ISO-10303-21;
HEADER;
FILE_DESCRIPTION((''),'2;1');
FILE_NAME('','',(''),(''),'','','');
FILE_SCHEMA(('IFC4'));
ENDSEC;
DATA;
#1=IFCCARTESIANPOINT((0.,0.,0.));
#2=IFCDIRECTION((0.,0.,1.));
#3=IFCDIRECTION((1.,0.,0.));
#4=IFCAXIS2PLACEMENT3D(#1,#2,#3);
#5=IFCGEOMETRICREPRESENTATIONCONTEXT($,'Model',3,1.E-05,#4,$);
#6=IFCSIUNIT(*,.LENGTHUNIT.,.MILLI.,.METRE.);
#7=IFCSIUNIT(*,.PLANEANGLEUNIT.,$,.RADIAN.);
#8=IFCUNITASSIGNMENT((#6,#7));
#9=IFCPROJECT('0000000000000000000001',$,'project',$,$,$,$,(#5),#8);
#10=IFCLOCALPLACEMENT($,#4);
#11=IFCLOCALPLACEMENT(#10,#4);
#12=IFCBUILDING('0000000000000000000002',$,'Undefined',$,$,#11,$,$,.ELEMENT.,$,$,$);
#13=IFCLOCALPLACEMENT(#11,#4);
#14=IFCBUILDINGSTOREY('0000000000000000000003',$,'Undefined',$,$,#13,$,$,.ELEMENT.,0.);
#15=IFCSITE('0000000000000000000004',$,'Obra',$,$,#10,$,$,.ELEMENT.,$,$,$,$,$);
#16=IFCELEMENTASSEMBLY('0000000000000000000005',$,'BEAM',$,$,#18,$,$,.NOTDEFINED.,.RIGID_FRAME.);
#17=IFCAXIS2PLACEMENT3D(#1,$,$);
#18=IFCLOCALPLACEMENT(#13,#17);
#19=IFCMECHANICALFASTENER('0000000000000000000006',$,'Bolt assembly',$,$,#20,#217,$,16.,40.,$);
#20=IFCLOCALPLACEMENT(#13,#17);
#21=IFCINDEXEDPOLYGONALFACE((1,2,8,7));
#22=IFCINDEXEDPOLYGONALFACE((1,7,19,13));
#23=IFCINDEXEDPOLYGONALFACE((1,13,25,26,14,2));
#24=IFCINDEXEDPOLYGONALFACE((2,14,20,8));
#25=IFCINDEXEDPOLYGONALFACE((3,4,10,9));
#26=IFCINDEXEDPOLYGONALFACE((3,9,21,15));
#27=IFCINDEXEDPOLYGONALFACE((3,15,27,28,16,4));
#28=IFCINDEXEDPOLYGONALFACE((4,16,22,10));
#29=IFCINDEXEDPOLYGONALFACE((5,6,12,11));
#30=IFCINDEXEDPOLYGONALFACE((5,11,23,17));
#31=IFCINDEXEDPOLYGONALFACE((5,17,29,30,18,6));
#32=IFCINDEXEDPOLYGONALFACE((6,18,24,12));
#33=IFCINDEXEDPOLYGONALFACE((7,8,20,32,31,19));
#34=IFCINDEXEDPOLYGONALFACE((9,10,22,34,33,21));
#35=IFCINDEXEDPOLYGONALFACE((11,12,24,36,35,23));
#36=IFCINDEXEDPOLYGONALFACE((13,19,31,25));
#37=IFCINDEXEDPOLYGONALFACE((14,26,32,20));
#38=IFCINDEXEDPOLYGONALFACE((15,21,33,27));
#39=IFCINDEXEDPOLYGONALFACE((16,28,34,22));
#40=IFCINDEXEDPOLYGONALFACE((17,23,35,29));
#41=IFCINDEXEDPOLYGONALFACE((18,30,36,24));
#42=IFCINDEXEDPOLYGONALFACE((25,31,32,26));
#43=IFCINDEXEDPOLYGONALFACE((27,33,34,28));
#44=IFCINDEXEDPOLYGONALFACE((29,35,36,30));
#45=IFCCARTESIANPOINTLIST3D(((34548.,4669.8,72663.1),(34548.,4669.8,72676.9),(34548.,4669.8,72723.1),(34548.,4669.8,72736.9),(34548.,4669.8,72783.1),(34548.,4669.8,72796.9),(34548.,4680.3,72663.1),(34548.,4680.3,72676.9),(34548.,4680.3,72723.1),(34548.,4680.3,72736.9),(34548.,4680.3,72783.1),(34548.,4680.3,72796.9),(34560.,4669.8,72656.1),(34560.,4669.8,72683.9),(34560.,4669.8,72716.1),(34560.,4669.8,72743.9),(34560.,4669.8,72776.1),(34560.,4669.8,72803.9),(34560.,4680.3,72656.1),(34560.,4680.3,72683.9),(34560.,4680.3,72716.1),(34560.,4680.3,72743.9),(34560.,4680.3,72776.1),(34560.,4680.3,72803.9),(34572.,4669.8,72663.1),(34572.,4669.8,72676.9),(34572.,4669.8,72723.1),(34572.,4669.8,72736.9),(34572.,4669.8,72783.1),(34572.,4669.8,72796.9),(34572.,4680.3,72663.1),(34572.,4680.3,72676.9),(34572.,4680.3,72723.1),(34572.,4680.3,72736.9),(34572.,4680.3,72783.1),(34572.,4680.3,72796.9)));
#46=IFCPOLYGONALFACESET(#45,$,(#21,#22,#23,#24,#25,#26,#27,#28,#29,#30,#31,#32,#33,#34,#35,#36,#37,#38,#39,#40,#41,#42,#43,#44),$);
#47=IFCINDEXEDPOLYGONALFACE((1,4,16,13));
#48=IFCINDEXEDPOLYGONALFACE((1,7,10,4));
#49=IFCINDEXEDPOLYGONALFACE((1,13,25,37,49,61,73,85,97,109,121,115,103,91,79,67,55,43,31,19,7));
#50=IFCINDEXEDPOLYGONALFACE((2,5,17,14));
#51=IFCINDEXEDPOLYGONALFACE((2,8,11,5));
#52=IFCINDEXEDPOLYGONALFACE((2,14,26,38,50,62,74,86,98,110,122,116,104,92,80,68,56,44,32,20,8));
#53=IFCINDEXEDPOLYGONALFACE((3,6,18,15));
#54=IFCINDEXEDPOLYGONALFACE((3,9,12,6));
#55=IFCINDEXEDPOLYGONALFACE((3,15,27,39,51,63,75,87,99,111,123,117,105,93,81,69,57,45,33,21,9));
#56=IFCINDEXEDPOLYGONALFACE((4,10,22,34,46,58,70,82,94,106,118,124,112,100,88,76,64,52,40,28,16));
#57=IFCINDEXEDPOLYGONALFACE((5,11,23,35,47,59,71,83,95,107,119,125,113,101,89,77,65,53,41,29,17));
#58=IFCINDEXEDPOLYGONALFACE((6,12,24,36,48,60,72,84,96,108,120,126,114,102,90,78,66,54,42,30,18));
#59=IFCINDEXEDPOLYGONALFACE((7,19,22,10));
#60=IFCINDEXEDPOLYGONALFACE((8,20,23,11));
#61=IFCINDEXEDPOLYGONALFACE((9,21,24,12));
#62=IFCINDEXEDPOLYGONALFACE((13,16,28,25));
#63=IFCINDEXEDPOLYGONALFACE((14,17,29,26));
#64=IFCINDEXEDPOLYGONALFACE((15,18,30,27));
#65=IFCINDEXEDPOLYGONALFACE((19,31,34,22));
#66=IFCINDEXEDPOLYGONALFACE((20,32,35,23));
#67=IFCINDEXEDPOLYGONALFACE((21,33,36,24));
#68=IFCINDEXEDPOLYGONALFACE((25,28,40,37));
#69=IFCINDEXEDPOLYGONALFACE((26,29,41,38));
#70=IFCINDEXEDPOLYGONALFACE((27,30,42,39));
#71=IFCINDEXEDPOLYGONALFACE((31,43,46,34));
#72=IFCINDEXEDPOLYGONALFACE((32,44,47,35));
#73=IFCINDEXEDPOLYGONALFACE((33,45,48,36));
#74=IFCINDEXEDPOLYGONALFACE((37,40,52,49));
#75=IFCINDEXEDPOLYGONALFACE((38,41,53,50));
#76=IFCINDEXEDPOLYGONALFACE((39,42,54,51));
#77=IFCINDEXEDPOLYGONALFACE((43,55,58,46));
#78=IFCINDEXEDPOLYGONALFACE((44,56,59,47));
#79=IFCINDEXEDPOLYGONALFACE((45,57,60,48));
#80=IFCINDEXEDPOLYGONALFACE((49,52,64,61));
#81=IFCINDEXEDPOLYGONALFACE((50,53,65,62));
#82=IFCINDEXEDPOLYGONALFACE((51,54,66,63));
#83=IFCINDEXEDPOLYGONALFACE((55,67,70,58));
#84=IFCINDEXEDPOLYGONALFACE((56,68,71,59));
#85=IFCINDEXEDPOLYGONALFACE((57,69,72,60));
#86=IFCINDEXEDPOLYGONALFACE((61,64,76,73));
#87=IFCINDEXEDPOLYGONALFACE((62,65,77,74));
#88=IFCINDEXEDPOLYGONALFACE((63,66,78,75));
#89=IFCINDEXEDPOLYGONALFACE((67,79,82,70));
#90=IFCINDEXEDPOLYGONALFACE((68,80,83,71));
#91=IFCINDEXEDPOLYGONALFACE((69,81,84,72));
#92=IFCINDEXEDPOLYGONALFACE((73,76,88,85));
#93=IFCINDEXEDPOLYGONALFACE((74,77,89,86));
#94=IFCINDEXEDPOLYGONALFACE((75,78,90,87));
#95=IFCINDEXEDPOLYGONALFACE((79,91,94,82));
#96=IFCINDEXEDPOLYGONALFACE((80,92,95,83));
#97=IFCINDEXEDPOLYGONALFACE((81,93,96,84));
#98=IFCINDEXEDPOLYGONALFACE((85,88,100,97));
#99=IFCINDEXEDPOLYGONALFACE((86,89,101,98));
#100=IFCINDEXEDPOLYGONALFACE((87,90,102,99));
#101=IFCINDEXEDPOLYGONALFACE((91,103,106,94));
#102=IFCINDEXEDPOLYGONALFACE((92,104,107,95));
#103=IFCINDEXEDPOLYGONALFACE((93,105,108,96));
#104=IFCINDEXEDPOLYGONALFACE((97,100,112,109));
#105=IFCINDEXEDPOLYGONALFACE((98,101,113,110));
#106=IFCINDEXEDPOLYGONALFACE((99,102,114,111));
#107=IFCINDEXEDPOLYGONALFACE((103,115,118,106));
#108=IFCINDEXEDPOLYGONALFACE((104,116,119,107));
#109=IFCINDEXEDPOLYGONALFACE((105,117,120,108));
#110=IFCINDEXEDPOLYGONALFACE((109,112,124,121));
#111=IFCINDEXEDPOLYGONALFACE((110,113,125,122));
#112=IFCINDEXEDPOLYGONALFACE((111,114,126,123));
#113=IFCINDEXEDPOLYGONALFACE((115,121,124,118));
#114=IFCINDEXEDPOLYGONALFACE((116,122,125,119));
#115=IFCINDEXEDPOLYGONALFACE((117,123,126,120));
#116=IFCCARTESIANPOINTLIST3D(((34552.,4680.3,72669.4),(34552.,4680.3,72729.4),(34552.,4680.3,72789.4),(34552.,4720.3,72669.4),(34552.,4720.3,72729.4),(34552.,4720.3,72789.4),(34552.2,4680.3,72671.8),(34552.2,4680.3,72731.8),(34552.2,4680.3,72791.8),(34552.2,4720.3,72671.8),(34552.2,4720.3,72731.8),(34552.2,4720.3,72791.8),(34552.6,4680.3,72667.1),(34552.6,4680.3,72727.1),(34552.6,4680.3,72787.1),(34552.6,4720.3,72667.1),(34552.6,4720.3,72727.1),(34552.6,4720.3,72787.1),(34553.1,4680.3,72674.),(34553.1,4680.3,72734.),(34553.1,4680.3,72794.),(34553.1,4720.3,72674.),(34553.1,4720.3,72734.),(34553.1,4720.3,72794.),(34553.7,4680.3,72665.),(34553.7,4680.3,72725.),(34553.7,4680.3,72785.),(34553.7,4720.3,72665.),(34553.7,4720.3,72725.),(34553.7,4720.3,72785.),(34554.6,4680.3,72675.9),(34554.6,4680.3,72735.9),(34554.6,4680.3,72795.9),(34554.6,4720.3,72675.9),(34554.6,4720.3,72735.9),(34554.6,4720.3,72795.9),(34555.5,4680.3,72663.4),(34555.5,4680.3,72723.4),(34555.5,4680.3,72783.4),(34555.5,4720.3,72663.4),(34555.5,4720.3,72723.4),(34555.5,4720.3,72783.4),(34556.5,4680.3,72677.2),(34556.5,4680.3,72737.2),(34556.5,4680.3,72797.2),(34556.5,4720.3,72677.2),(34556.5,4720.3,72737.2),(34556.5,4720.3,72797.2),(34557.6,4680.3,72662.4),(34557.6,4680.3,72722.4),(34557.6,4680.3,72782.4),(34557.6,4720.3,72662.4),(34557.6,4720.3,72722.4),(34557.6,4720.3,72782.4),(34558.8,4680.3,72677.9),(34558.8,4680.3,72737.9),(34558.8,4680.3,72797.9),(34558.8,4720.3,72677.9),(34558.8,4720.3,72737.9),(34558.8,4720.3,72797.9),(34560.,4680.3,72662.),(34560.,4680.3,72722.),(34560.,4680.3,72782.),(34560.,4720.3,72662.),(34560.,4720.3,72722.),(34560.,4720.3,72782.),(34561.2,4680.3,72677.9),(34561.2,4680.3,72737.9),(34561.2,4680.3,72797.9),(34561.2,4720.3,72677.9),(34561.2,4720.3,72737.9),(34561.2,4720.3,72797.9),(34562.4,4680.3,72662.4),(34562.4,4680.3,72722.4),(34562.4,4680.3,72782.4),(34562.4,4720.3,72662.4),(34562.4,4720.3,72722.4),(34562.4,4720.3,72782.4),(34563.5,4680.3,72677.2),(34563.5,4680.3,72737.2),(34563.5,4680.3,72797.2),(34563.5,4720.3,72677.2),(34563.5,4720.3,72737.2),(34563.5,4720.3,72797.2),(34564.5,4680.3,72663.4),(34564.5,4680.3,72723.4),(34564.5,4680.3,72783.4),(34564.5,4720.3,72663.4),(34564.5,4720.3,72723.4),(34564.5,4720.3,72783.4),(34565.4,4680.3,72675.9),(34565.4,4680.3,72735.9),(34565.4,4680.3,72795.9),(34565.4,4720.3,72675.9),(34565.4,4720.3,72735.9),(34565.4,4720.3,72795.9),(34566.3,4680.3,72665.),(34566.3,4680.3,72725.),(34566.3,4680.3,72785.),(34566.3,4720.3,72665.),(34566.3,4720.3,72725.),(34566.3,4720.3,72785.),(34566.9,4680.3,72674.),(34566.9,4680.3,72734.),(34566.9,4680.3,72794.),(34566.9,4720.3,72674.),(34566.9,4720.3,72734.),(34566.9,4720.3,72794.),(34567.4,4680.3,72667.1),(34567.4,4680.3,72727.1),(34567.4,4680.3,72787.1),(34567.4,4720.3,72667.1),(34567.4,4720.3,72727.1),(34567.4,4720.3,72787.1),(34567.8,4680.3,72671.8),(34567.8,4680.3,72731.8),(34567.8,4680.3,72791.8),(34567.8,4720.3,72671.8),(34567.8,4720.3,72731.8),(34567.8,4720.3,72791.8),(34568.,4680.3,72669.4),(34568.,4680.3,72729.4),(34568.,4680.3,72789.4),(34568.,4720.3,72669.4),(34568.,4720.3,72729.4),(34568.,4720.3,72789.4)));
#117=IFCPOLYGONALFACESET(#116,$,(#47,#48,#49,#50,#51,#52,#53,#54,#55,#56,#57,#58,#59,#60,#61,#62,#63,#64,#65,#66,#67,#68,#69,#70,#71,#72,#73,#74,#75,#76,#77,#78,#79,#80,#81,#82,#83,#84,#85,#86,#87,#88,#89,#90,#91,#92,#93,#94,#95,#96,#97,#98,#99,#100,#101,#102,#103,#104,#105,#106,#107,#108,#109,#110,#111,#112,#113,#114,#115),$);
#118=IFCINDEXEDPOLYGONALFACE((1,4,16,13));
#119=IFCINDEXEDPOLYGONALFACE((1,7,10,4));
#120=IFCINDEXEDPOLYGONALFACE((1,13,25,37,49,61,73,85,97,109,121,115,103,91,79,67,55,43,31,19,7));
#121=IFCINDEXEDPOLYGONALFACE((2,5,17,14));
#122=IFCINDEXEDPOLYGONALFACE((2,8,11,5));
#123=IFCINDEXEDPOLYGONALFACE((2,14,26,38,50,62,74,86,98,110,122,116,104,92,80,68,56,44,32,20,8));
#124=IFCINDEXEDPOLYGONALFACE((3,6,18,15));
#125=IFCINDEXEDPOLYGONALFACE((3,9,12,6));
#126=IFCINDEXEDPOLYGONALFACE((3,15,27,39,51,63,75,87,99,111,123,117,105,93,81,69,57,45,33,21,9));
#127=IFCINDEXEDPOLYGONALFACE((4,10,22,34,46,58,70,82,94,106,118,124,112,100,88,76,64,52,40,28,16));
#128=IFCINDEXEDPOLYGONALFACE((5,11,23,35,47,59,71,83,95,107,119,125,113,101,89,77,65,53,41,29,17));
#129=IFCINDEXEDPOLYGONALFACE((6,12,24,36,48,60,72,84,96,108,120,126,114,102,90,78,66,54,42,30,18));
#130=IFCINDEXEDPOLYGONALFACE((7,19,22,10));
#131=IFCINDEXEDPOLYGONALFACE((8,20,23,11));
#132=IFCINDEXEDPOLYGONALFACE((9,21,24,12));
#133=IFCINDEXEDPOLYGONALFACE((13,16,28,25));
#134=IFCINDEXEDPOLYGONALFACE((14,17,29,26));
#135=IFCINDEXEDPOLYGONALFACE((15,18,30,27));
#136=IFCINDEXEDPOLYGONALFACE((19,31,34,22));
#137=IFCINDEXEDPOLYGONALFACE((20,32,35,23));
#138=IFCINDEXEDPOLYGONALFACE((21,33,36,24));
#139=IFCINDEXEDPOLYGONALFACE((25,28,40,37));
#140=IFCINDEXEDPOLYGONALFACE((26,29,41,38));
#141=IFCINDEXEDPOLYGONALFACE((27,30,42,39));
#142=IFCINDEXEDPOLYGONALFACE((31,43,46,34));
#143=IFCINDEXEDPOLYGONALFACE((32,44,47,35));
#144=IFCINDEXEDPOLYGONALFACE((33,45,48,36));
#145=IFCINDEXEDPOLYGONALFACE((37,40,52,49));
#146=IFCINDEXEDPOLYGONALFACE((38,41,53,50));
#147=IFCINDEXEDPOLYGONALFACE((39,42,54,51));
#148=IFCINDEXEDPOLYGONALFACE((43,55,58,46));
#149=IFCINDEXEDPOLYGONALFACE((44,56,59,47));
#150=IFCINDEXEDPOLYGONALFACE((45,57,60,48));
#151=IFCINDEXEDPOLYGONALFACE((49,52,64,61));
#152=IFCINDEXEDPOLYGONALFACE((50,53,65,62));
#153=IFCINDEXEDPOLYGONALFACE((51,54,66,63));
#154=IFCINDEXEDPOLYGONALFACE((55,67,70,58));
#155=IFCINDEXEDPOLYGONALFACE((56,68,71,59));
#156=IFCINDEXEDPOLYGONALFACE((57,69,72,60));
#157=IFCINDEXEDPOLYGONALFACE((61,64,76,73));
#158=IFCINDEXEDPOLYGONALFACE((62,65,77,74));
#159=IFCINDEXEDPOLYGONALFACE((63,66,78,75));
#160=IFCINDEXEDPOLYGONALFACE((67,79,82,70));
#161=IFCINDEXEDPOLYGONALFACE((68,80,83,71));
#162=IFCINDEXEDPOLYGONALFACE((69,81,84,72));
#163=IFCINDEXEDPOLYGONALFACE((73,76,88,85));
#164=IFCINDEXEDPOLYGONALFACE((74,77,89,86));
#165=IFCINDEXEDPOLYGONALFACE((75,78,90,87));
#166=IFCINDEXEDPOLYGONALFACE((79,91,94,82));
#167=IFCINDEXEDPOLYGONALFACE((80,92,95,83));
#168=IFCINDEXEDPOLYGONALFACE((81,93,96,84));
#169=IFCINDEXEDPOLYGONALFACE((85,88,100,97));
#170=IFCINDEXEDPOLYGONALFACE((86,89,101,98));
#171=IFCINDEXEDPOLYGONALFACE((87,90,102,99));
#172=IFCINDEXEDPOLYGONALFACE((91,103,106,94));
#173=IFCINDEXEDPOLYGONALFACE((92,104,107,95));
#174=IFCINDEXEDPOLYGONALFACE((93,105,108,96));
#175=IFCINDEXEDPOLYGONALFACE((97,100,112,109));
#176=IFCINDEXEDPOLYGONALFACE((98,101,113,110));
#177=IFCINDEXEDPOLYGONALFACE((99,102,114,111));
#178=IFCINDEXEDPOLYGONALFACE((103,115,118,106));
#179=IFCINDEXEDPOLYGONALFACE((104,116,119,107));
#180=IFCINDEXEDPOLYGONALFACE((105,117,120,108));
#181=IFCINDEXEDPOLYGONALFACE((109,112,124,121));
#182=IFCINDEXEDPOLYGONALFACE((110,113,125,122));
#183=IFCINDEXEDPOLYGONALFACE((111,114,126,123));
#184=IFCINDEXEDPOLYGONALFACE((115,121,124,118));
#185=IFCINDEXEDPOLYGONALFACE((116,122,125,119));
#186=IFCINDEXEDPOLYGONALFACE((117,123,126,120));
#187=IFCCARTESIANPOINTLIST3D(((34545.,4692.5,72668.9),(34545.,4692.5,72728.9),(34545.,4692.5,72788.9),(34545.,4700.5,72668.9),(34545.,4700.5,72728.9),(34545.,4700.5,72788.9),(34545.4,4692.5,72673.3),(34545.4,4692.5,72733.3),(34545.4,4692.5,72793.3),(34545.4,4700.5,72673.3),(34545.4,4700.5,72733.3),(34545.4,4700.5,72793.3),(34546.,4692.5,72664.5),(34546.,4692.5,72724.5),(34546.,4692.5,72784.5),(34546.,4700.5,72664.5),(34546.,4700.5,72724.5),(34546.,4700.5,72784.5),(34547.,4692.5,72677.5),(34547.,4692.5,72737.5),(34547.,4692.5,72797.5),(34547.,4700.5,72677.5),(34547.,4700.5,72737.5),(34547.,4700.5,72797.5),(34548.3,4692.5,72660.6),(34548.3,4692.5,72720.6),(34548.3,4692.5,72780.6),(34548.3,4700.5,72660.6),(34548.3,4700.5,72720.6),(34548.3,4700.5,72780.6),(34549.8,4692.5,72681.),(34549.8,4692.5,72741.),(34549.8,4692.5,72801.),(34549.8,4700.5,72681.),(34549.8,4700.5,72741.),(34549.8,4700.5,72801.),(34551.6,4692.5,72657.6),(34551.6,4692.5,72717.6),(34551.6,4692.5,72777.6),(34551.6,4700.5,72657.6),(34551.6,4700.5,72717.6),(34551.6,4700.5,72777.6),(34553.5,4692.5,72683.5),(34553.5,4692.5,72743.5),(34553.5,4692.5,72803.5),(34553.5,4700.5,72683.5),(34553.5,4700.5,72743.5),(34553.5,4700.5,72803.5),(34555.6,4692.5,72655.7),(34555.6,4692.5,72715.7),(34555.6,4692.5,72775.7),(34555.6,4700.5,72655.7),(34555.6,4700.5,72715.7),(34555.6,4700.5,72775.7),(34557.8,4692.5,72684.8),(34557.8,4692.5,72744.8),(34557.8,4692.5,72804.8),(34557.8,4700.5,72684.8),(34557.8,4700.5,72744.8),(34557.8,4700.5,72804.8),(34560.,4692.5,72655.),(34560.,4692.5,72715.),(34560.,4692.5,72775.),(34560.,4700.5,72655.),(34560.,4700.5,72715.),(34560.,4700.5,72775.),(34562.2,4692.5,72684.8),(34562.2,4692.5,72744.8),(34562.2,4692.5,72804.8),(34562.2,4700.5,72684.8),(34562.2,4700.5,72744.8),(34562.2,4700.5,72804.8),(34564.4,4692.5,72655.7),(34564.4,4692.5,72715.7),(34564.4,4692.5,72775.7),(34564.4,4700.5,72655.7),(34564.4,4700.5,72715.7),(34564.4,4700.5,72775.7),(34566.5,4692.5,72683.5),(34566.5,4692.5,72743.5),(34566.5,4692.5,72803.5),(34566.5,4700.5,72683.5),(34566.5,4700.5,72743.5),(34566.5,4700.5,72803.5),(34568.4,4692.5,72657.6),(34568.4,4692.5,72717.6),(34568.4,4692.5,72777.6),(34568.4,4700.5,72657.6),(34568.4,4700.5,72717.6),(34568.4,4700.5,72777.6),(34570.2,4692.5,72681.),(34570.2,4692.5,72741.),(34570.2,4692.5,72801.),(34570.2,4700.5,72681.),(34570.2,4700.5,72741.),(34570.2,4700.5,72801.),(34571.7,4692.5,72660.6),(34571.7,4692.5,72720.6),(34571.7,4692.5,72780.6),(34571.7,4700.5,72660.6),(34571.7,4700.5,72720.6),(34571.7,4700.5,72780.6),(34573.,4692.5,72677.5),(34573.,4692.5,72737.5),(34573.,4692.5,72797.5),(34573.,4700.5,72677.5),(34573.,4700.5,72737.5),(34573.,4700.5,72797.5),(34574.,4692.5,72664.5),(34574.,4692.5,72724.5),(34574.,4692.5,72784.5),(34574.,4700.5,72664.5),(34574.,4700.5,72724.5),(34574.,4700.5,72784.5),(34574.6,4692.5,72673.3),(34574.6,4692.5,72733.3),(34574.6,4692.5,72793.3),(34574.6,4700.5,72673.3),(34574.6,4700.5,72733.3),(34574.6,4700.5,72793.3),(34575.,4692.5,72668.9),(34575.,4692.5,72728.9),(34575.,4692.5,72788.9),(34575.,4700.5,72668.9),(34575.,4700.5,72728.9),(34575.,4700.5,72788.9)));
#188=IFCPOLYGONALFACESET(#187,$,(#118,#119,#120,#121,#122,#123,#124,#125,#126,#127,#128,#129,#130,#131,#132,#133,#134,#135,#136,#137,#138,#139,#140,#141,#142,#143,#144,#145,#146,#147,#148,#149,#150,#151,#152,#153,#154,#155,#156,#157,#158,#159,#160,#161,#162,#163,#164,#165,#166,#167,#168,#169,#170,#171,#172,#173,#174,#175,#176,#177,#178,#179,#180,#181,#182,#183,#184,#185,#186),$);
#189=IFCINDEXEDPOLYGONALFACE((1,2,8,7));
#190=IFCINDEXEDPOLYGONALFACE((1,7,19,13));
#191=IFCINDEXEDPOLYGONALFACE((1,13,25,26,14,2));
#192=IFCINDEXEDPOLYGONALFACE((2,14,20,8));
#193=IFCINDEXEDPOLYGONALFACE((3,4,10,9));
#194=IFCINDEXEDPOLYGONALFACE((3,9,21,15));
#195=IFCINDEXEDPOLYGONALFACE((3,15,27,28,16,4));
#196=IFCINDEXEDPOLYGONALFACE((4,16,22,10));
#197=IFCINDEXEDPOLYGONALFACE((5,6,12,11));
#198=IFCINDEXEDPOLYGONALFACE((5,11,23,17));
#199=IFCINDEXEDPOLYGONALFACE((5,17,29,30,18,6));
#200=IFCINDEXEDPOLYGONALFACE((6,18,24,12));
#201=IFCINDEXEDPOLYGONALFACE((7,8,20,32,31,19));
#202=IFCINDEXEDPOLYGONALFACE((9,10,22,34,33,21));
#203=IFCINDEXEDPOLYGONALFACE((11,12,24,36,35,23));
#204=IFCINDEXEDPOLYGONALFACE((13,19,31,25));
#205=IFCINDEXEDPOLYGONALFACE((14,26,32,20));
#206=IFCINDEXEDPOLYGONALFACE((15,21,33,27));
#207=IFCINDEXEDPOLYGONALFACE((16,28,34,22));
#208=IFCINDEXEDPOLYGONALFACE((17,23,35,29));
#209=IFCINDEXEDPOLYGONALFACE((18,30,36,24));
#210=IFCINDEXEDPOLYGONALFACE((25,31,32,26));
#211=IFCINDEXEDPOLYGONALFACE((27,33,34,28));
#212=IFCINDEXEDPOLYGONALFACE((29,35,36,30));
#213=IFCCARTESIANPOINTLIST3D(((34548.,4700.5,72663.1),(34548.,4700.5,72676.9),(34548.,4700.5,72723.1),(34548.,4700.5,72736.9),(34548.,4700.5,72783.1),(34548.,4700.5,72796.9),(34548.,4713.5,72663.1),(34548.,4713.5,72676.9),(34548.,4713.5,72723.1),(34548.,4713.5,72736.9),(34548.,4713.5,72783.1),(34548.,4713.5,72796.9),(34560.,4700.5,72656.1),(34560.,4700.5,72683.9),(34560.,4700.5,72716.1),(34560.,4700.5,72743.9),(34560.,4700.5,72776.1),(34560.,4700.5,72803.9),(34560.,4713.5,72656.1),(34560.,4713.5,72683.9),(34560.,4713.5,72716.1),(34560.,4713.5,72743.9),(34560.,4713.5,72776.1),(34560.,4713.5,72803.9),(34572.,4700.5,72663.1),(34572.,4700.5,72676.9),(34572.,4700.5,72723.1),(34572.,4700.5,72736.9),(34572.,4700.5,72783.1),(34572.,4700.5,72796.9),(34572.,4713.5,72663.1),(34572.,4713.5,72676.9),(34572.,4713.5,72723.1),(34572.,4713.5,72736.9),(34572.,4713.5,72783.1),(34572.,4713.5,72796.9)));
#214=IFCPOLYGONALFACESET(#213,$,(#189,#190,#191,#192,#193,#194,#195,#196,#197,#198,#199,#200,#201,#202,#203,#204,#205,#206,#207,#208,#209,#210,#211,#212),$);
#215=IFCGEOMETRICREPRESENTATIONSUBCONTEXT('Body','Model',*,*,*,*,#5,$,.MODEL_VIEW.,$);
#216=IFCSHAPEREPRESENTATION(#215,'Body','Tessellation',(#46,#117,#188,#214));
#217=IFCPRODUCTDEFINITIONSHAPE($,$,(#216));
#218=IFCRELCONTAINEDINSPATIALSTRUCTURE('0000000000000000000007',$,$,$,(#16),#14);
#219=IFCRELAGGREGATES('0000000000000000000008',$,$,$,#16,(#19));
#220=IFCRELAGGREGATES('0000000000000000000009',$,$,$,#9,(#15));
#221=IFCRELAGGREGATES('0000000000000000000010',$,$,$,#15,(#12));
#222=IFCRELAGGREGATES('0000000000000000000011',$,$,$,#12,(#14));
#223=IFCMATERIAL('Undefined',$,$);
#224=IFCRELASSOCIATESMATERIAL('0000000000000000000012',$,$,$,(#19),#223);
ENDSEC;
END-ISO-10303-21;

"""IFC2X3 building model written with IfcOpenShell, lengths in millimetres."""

from ifc_helpers import new_model, si_unit, frame, origin_with_axes, origin_2d_with_axis, place, context, subcontext, project, spatial, polyline, circle, outline, extrude, source, transform, mapped, material, element, aggregate, save


model = new_model("IFC2X3")

# Units and contexts
model_context = context("Model", 3, precision=1e-05, world=origin_with_axes())
body_context = subcontext(model_context, "Body", "Model", "MODEL_VIEW")
ifc_project = project(units=[si_unit("LENGTHUNIT", "METRE", prefix="MILLI"), si_unit("PLANEANGLEUNIT", "RADIAN")], contexts=[model_context])

# Site, building, storey
site_placement = place(None, origin_with_axes())
site = spatial("IfcSite", under=ifc_project, at=site_placement, Name="Obra", CompositionType="ELEMENT")
building_placement = place(site_placement, origin_with_axes())
building = spatial("IfcBuilding", under=site, at=building_placement, Name="Undefined", CompositionType="ELEMENT")
storey_placement = place(building_placement, origin_with_axes())
storey = spatial("IfcBuildingStorey", under=building, at=storey_placement, Name="Undefined", CompositionType="ELEMENT", Elevation=0.0)

# Shared definitions
ifc_material = material(Name="Undefined")

# Element assembly, mechanical fastener
assembly_1_placement = place(storey_placement, origin_with_axes())
assembly_1 = element("IfcElementAssembly", 1, at=assembly_1_placement, inside=storey, Name="BEAM", AssemblyPlace="NOTDEFINED", PredefinedType="RIGID_FRAME")
shared_shape_1 = source(origin_with_axes(), body_context, "Body", "SweptSolid", [
    extrude(outline(polyline([(13.9, 0.0), (6.9, 12.0), (-6.9, 12.0), (-13.9, 0.0), (-6.9, -12.0), (6.9, -12.0), (13.9, 0.0)])), frame((0.0, -19.7, 0.0), z_axis=(0.0, 1.0, 0.0), x_axis=(1.0, 0.0, 0.0)), (0.0, 0.0, 1.0), 10.6),
    extrude(circle(Radius=8.0, at=origin_2d_with_axis()), frame((0.0, -9.1, 0.0), z_axis=(0.0, 1.0, 0.0), x_axis=(1.0, 0.0, 0.0)), (0.0, 0.0, 1.0), 40.0),
    extrude(circle(Radius=15.0, at=origin_2d_with_axis()), frame((0.0, 3.1, 0.0), z_axis=(0.0, 1.0, 0.0), x_axis=(1.0, 0.0, 0.0)), (0.0, 0.0, 1.0), 8.0),
    extrude(outline(polyline([(13.9, 0.0), (6.9, 12.0), (-6.9, 12.0), (-13.9, 0.0), (-6.9, -12.0), (6.9, -12.0), (13.9, 0.0)])), frame((0.0, 11.1, 0.0), z_axis=(0.0, 1.0, 0.0), x_axis=(1.0, 0.0, 0.0)), (0.0, 0.0, 1.0), 13.0),
])
mechanical_fastener_1_placement = place(assembly_1_placement, frame((34510.0, 4689.4, 72850.0), z_axis=(1.0, 0.0, 0.0), x_axis=(0.0, 0.0, -1.0)))
mechanical_fastener_1 = element("IfcMechanicalFastener", 2, at=mechanical_fastener_1_placement, material=ifc_material, Name="Bolt assembly", NominalDiameter=16.0, NominalLength=40.0, context=body_context, shape_type="MappedRepresentation", body=[
    mapped(shared_shape_1, transform((60.0, 0.0, 50.0))),
    mapped(shared_shape_1, transform((120.0, 0.0, 50.0))),
    mapped(shared_shape_1, transform((180.0, 0.0, 50.0))),
])
aggregate(assembly_1, [mechanical_fastener_1])

save(model, "model.ifc")
